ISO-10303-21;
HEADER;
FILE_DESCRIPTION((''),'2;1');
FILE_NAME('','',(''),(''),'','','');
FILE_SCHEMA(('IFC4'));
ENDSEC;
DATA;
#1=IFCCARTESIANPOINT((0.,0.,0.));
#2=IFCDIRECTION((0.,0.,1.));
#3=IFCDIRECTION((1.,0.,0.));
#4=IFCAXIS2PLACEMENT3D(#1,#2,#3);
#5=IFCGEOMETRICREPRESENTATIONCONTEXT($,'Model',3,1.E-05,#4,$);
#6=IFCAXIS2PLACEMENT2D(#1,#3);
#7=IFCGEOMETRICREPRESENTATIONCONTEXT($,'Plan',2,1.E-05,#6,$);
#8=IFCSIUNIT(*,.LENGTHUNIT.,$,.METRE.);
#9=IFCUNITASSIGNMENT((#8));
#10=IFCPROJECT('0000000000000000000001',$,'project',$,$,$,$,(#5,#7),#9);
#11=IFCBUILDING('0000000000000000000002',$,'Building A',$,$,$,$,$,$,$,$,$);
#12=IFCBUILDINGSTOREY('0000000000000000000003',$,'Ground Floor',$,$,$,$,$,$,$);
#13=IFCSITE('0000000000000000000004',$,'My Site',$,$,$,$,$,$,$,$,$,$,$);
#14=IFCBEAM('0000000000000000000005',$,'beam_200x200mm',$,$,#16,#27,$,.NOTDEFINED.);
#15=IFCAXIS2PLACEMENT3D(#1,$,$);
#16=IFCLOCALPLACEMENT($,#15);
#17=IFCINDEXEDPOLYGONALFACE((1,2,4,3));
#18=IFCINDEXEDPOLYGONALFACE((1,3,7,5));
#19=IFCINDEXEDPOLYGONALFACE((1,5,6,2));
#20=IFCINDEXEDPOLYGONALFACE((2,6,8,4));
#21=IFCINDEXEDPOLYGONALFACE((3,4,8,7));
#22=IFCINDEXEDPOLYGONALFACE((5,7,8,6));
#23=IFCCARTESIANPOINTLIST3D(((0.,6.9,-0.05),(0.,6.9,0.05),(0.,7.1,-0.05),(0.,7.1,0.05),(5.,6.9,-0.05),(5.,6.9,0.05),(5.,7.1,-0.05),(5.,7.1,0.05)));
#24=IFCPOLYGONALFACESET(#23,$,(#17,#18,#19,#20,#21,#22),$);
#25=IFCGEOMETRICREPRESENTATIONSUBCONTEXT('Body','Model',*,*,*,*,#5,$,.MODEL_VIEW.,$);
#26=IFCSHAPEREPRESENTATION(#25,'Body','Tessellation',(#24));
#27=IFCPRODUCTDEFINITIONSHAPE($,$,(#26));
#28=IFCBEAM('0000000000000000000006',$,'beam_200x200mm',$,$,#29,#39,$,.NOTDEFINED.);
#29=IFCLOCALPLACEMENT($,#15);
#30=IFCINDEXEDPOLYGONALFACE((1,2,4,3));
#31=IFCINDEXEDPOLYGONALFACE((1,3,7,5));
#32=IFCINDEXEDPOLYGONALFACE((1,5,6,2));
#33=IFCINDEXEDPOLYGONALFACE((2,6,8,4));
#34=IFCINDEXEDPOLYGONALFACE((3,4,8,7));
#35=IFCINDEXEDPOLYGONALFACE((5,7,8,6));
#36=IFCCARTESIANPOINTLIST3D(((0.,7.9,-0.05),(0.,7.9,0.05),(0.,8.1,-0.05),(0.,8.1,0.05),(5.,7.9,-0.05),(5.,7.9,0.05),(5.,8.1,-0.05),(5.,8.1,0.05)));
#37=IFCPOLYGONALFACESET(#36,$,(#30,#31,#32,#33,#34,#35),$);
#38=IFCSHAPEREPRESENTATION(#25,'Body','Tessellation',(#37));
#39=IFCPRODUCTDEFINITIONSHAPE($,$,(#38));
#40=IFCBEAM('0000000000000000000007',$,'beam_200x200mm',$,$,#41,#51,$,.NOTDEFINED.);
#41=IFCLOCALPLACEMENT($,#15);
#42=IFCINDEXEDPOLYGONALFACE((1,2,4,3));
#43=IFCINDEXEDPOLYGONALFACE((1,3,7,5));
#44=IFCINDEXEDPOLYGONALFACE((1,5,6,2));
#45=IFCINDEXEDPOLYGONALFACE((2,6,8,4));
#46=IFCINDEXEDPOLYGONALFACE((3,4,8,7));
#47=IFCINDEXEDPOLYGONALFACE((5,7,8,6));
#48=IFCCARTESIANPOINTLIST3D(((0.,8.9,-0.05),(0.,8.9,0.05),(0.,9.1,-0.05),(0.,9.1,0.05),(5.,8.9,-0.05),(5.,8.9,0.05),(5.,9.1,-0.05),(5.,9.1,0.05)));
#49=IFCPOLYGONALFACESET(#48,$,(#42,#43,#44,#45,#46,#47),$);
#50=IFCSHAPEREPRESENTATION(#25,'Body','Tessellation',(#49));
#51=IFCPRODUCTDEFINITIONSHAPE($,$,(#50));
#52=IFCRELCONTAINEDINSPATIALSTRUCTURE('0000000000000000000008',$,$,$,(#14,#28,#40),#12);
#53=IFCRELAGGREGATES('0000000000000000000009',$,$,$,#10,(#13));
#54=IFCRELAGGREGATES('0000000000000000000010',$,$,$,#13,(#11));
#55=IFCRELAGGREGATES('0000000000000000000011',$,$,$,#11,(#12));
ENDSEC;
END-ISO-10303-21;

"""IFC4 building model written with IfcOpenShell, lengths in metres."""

from ifc_helpers import new_model, si_unit, frame, frame_2d, origin_with_axes, place, context, subcontext, project, spatial, rectangle, extrude, element, save


model = new_model("IFC4")

# Units and contexts
model_context = context("Model", 3, precision=1e-05, world=origin_with_axes())
plan_context = context("Plan", 2, precision=1e-05, world=frame_2d((0.0, 0.0, 0.0), x_axis=(1.0, 0.0, 0.0)))
body_context = subcontext(model_context, "Body", "Model", "MODEL_VIEW")
ifc_project = project(units=[si_unit("LENGTHUNIT", "METRE")], contexts=[model_context, plan_context])

# Site, building, storey
site = spatial("IfcSite", under=ifc_project, Name="My Site")
building = spatial("IfcBuilding", under=site, Name="Building A")
storey = spatial("IfcBuildingStorey", under=building, Name="Ground Floor")

# Beams
for number, where, z_axis, x_axis, name in (
    (1, (0.0, 7.0, 0.0), (1.0, 0.0, 0.0), (0.0, 0.0, 1.0), "beam_200x200mm"),
    (2, (0.0, 8.0, 0.0), (1.0, 0.0, 0.0), (0.0, 0.0, 1.0), "beam_200x200mm"),
    (3, (0.0, 9.0, 0.0), (1.0, 0.0, 0.0), (0.0, 0.0, 1.0), "beam_200x200mm"),
):
    element("IfcBeam", number, at=place(None, frame(where, z_axis=z_axis, x_axis=x_axis)), inside=storey, Name=name, PredefinedType="NOTDEFINED", context=body_context, shape_type="SweptSolid", body=[
        extrude(rectangle(XDim=0.1, YDim=0.2), origin_with_axes(), (0.0, 0.0, 1.0), 5.0),
    ])

save(model, "model.ifc")
